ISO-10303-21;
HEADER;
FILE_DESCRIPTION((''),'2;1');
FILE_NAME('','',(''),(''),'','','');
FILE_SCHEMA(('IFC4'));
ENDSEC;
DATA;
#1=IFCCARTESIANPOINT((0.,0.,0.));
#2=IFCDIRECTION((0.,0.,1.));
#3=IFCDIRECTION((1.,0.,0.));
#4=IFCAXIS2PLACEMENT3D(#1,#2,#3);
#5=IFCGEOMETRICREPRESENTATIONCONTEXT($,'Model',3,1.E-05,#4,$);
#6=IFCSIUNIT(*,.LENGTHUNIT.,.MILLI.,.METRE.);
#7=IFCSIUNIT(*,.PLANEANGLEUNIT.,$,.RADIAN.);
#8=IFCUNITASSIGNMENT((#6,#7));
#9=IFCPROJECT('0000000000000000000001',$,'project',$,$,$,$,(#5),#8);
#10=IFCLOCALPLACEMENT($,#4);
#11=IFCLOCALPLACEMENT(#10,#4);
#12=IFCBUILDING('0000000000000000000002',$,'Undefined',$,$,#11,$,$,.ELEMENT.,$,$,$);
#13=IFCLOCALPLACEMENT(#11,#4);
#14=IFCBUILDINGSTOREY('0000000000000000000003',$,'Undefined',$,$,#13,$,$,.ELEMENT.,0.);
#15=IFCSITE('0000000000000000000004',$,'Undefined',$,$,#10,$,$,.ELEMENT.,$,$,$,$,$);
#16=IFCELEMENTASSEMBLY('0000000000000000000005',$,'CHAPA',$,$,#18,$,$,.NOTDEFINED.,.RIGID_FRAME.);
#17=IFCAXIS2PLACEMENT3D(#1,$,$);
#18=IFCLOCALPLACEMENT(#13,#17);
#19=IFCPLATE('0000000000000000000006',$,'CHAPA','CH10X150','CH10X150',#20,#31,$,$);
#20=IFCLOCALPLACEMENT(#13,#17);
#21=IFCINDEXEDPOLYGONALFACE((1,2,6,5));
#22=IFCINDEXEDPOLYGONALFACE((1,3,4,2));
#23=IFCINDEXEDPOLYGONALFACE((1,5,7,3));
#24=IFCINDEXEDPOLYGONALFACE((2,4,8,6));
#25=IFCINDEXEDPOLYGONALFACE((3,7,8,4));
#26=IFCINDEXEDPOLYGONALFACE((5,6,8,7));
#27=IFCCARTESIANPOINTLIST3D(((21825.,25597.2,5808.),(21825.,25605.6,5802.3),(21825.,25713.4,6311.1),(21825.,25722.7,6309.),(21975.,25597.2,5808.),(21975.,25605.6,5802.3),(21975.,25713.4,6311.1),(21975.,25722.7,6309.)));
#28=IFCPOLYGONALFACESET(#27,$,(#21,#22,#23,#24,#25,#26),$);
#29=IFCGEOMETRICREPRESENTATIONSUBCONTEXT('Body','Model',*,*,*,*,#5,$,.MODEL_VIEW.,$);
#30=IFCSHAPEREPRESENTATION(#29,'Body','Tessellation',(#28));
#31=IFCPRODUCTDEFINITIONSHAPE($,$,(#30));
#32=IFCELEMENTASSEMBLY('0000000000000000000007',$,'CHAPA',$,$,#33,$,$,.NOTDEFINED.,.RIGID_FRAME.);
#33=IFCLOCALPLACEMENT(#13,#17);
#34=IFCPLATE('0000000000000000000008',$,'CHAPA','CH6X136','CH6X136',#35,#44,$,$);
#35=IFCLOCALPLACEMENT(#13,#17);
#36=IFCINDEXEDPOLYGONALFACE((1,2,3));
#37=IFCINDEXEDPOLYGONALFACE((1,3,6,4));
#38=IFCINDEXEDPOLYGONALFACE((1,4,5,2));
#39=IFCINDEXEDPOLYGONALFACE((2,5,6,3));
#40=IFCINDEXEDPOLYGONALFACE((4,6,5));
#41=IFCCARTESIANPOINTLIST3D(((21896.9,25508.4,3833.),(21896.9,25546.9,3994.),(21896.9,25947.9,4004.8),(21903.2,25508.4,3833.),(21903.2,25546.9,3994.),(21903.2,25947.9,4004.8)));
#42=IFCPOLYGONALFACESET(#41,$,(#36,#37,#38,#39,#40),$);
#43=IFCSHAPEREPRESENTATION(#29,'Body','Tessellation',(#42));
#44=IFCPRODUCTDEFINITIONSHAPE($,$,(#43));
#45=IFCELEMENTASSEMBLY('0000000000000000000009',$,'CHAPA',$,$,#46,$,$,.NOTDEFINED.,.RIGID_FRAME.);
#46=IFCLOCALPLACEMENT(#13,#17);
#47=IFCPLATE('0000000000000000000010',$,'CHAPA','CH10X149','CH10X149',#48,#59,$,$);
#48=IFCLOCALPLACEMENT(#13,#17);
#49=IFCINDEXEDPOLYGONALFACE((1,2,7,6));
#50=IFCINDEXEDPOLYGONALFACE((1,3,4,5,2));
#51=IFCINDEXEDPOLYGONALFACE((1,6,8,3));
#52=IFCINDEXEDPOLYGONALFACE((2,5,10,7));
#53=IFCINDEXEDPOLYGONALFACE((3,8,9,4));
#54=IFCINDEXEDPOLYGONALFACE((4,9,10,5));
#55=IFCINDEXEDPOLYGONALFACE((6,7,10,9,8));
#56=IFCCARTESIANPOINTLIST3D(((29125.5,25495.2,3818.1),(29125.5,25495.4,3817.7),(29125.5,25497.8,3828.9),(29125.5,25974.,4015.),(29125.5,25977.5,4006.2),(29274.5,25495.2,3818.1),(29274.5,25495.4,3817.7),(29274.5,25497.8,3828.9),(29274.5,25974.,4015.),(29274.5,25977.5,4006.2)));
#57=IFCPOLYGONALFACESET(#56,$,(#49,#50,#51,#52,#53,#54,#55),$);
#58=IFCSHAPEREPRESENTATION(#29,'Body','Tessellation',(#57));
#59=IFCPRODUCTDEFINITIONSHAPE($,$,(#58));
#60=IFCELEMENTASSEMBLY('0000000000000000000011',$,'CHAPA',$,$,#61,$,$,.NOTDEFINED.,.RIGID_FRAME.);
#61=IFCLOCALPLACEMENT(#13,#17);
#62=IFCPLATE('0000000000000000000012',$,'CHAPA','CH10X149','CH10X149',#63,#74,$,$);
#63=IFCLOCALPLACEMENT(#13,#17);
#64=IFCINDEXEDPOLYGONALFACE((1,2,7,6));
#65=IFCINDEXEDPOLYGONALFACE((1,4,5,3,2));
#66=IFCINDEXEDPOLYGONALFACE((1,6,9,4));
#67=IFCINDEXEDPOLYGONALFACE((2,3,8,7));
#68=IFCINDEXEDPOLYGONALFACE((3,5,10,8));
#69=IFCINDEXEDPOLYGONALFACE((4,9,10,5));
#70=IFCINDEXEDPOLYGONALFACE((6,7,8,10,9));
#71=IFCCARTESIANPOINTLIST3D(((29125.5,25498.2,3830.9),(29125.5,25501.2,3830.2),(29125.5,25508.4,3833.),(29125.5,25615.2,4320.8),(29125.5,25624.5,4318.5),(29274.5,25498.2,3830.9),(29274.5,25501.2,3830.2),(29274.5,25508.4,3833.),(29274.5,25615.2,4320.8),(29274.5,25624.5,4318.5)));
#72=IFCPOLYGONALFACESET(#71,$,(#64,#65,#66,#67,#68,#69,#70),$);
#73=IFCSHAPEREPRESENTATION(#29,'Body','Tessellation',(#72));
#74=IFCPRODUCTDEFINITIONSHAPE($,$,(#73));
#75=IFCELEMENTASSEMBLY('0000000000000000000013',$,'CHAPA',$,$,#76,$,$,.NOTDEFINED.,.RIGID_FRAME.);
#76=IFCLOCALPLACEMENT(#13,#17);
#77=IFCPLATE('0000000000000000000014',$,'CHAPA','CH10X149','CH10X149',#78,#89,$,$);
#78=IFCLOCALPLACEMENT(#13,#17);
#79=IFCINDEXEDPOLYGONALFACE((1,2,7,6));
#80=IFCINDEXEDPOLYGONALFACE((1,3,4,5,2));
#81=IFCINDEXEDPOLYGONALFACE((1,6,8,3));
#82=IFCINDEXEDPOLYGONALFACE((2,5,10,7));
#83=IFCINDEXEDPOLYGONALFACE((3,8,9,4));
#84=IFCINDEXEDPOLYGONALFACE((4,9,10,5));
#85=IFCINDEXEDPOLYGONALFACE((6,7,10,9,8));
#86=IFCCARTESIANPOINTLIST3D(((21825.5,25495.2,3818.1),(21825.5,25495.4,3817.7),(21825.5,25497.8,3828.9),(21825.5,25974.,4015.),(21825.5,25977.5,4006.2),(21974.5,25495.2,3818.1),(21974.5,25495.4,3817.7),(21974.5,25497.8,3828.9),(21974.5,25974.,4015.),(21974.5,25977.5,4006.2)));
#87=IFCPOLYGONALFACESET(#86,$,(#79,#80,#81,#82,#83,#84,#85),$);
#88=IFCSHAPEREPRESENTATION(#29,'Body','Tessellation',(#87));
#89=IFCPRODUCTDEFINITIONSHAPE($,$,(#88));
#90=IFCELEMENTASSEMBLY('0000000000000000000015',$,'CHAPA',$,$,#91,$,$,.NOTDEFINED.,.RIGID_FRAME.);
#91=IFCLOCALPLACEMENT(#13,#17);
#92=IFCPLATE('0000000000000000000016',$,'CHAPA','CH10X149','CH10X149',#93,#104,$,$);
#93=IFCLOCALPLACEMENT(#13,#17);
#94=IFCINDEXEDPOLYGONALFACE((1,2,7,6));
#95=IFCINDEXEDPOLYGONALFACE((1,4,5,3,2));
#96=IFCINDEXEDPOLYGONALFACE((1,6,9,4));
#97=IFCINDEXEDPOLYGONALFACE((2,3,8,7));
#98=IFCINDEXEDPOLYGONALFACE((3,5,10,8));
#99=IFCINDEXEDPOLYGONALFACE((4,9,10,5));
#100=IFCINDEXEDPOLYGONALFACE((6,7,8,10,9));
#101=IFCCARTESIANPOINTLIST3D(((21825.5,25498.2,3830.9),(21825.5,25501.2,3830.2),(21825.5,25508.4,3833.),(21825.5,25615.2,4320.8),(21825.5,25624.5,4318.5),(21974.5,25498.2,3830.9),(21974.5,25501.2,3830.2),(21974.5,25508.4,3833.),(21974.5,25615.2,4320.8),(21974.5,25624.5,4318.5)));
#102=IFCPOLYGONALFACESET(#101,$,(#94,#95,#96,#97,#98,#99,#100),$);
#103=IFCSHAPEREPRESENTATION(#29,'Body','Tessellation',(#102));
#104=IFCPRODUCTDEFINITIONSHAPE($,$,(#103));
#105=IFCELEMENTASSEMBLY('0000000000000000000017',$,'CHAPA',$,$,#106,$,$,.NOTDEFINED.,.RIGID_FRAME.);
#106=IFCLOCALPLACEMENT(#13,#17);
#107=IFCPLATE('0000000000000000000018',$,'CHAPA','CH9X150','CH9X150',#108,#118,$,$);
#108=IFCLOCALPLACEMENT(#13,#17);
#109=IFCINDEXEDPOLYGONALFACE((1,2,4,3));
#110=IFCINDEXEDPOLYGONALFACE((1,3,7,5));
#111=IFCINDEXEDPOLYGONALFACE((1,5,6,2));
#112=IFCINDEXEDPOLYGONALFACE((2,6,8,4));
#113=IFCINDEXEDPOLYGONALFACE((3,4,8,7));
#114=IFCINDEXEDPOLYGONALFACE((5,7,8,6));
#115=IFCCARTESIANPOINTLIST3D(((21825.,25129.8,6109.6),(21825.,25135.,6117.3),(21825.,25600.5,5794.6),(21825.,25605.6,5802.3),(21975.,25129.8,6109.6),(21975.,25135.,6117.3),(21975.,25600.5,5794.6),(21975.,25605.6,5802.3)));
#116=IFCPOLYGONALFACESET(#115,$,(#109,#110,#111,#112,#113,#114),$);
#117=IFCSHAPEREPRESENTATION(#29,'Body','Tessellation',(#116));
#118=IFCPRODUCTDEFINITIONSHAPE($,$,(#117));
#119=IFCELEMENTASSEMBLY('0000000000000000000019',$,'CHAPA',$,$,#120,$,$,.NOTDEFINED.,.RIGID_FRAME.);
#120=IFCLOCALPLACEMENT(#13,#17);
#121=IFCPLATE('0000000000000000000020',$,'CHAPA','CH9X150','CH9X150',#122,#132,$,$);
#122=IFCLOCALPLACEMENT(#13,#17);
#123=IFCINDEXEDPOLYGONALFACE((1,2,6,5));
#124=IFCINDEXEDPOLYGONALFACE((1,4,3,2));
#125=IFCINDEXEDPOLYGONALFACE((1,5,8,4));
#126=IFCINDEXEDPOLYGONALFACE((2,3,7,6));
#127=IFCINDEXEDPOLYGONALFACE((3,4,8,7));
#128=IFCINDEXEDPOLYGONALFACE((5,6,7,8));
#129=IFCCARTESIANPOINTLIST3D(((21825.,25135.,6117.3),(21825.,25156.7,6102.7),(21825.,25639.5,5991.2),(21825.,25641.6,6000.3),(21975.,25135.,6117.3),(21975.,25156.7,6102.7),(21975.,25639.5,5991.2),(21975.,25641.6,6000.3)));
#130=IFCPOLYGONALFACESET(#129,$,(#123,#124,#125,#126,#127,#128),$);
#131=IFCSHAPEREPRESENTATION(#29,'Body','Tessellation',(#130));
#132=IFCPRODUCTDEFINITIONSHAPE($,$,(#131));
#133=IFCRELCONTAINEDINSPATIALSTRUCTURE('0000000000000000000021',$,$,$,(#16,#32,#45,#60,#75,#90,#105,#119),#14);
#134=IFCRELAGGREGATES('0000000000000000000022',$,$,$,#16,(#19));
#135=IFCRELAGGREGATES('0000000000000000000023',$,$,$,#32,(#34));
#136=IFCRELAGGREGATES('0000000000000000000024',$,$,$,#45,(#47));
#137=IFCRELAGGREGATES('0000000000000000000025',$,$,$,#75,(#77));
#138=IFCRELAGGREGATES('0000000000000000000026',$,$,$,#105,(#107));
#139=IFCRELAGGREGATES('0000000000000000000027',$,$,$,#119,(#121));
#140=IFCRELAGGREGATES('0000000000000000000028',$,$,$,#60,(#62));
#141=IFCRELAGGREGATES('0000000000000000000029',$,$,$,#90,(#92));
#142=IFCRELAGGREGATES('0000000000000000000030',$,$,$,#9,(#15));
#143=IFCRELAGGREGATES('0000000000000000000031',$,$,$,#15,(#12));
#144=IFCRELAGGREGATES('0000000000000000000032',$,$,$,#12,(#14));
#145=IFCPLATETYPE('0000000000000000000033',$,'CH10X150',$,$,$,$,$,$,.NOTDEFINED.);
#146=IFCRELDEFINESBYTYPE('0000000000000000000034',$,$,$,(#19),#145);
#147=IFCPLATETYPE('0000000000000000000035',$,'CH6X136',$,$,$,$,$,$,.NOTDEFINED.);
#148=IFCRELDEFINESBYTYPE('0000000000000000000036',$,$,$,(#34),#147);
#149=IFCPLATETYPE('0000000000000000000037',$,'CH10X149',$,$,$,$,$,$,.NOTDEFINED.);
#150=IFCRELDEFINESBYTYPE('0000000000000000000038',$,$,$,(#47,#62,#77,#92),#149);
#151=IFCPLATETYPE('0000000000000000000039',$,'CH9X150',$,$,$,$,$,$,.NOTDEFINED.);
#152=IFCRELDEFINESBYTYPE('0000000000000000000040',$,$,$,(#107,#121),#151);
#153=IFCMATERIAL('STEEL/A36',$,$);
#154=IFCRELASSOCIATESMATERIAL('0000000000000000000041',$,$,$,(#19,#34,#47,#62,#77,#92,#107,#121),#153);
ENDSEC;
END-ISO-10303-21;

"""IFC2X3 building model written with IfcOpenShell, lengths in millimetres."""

from ifc_helpers import new_model, si_unit, frame, origin_with_axes, place, context, subcontext, project, spatial, polyline, outline, extrude, clip, halfspace, material, type_object, element, aggregate, save


model = new_model("IFC2X3")

# Units and contexts
model_context = context("Model", 3, precision=1e-05, world=origin_with_axes())
body_context = subcontext(model_context, "Body", "Model", "MODEL_VIEW")
ifc_project = project(units=[si_unit("LENGTHUNIT", "METRE", prefix="MILLI"), si_unit("PLANEANGLEUNIT", "RADIAN")], contexts=[model_context])

# Site, building, storey
site_placement = place(None, origin_with_axes())
site = spatial("IfcSite", under=ifc_project, at=site_placement, Name="Undefined", CompositionType="ELEMENT")
building_placement = place(site_placement, origin_with_axes())
building = spatial("IfcBuilding", under=site, at=building_placement, Name="Undefined", CompositionType="ELEMENT")
storey_placement = place(building_placement, origin_with_axes())
storey = spatial("IfcBuildingStorey", under=building, at=storey_placement, Name="Undefined", CompositionType="ELEMENT", Elevation=0.0)

# Element assembly
assembly_1_placement = place(storey_placement, origin_with_axes())
assembly_1 = element("IfcElementAssembly", 1, at=assembly_1_placement, inside=storey, Name="CHAPA", AssemblyPlace="NOTDEFINED", PredefinedType="RIGID_FRAME")

# Plate
ifc_material_1 = material(Name="STEEL/A36")
plate_type_1 = type_object("IfcPlateType", Name="CH10X150", PredefinedType="NOTDEFINED")
plate_1_placement = place(assembly_1_placement, frame((21975.0, 25718.1, 6310.1), z_axis=(0.0, 0.97433, -0.225124), x_axis=(0.0, -0.225124, -0.97433)))
plate_1 = element("IfcPlate", 2, at=plate_1_placement, type_object=plate_type_1, material=ifc_material_1, Name="CHAPA", Description="CH10X150", ObjectType="CH10X150", context=body_context, shape_type="Clipping", body=[
    clip(extrude(outline(polyline([(0.0, 0.0), (520.0, 0.0), (520.0, 150.0), (0.0, 150.0), (0.0, 0.0)])), frame((0.0, 0.0, -4.8), z_axis=(0.0, 0.0, 1.0), x_axis=(1.0, 0.0, 0.0)), (0.0, 0.0, 1.0), 9.5), halfspace(frame((516.4, -500.0, -4.7), z_axis=(0.934951, 0.0, -0.354778), x_axis=(0.354778, 0.0, 0.934951)), False)),
])
aggregate(assembly_1, [plate_1])

# Element assemblies, plates
assembly_2_placement = place(storey_placement, origin_with_axes())
assembly_2 = element("IfcElementAssembly", 3, at=assembly_2_placement, inside=storey, Name="CHAPA", AssemblyPlace="NOTDEFINED", PredefinedType="RIGID_FRAME")
plate_type_2 = type_object("IfcPlateType", Name="CH6X136", PredefinedType="NOTDEFINED")
plate_2_placement = place(assembly_2_placement, frame((21900.0, 25546.9, 3994.0), z_axis=(-1.0, 0.0, 0.0), x_axis=(0.0, 0.999636, 0.026972)))
plate_2 = element("IfcPlate", 4, at=plate_2_placement, type_object=plate_type_2, material=ifc_material_1, Name="CHAPA", Description="CH6X136", ObjectType="CH6X136", context=body_context, shape_type="SweptSolid", body=[
    extrude(outline(polyline([(0.0, 0.0), (401.1, 0.0), (-42.8, 159.9), (0.0, 0.0)])), frame((0.0, 0.0, -3.1), z_axis=(0.0, 0.0, 1.0), x_axis=(1.0, 0.0, 0.0)), (0.0, 0.0, 1.0), 6.3),
])
aggregate(assembly_2, [plate_2])
assembly_3_placement = place(storey_placement, origin_with_axes())
assembly_3 = element("IfcElementAssembly", 5, at=assembly_3_placement, inside=storey, Name="CHAPA", AssemblyPlace="NOTDEFINED", PredefinedType="RIGID_FRAME")
plate_type_3 = type_object("IfcPlateType", Name="CH10X149", PredefinedType="NOTDEFINED")
plate_3_placement = place(assembly_3_placement, frame((29125.5, 25975.7, 4010.6), z_axis=(0.0, 0.364063, -0.931374), x_axis=(1.0, 0.0, 0.0)))
plate_3 = element("IfcPlate", 6, at=plate_3_placement, type_object=plate_type_3, material=ifc_material_1, Name="CHAPA", Description="CH10X149", ObjectType="CH10X149", context=body_context, shape_type="Clipping", body=[
    clip(extrude(outline(polyline([(0.0, 0.0), (149.0, 0.0), (149.0, 517.6), (0.0, 517.6), (0.0, 0.0)])), frame((0.0, 0.0, -4.8), z_axis=(0.0, 0.0, 1.0), x_axis=(1.0, 0.0, 0.0)), (0.0, 0.0, 1.0), 9.5), halfspace(frame((149.0, 517.9, 4.7), z_axis=(0.0, 0.821204, -0.570634), x_axis=(-1.0, 0.0, 0.0)), False)),
])
aggregate(assembly_3, [plate_3])
assembly_4_placement = place(storey_placement, origin_with_axes())
assembly_4 = element("IfcElementAssembly", 7, at=assembly_4_placement, inside=storey, Name="CHAPA", AssemblyPlace="NOTDEFINED", PredefinedType="RIGID_FRAME")
plate_4_placement = place(assembly_4_placement, frame((29125.5, 25619.9, 4319.6), z_axis=(0.0, 0.972612, -0.232434), x_axis=(1.0, 0.000007, 0.000031)))
plate_4 = element("IfcPlate", 8, at=plate_4_placement, type_object=plate_type_3, material=ifc_material_1, Name="CHAPA", Description="CH10X149", ObjectType="CH10X149", context=body_context, shape_type="Clipping", body=[
    clip(extrude(outline(polyline([(0.0, 0.0), (70.9, 0.0), (149.0, 0.0), (149.0, 503.6), (0.0, 503.6), (0.0, 0.0)])), frame((0.0, 0.0, -4.8), z_axis=(0.0, 0.0, 1.0), x_axis=(1.0, 0.0, 0.0)), (0.0, 0.0, 1.0), 9.5), halfspace(frame((70.9, 499.2, 4.7), z_axis=(-0.000026, 0.821245, 0.570575), x_axis=(-1.0, -0.000032, 0.0)), False)),
])
assembly_5_placement = place(storey_placement, origin_with_axes())
assembly_5 = element("IfcElementAssembly", 9, at=assembly_5_placement, inside=storey, Name="CHAPA", AssemblyPlace="NOTDEFINED", PredefinedType="RIGID_FRAME")
plate_5_placement = place(assembly_5_placement, frame((21825.5, 25975.7, 4010.6), z_axis=(0.0, 0.364063, -0.931374), x_axis=(1.0, 0.0, 0.0)))
plate_5 = element("IfcPlate", 10, at=plate_5_placement, type_object=plate_type_3, material=ifc_material_1, Name="CHAPA", Description="CH10X149", ObjectType="CH10X149", context=body_context, shape_type="Clipping", body=[
    clip(extrude(outline(polyline([(0.0, 0.0), (149.0, 0.0), (149.0, 517.6), (0.0, 517.6), (0.0, 0.0)])), frame((0.0, 0.0, -4.8), z_axis=(0.0, 0.0, 1.0), x_axis=(1.0, 0.0, 0.0)), (0.0, 0.0, 1.0), 9.5), halfspace(frame((149.0, 517.9, 4.7), z_axis=(0.0, 0.821204, -0.570634), x_axis=(-1.0, 0.0, 0.0)), False)),
])
aggregate(assembly_5, [plate_5])
assembly_6_placement = place(storey_placement, origin_with_axes())
assembly_6 = element("IfcElementAssembly", 11, at=assembly_6_placement, inside=storey, Name="CHAPA", AssemblyPlace="NOTDEFINED", PredefinedType="RIGID_FRAME")
plate_6_placement = place(assembly_6_placement, frame((21825.5, 25619.9, 4319.6), z_axis=(0.0, 0.972612, -0.232434), x_axis=(1.0, 0.000007, 0.000031)))
plate_6 = element("IfcPlate", 12, at=plate_6_placement, type_object=plate_type_3, material=ifc_material_1, Name="CHAPA", Description="CH10X149", ObjectType="CH10X149", context=body_context, shape_type="Clipping", body=[
    clip(extrude(outline(polyline([(0.0, 0.0), (70.9, 0.0), (149.0, 0.0), (149.0, 503.6), (0.0, 503.6), (0.0, 0.0)])), frame((0.0, 0.0, -4.8), z_axis=(0.0, 0.0, 1.0), x_axis=(1.0, 0.0, 0.0)), (0.0, 0.0, 1.0), 9.5), halfspace(frame((70.9, 499.2, 4.7), z_axis=(-0.000026, 0.821245, 0.570575), x_axis=(-1.0, -0.000032, 0.0)), False)),
])
assembly_7_placement = place(storey_placement, origin_with_axes())
assembly_7 = element("IfcElementAssembly", 13, at=assembly_7_placement, inside=storey, Name="CHAPA", AssemblyPlace="NOTDEFINED", PredefinedType="RIGID_FRAME")
plate_type_4 = type_object("IfcPlateType", Name="CH9X150", PredefinedType="NOTDEFINED")
plate_7_placement = place(assembly_7_placement, frame((21975.0, 25132.4, 6113.5), z_axis=(0.0, -0.55615, -0.831082), x_axis=(-1.0, 0.0, 0.0)))
plate_7 = element("IfcPlate", 14, at=plate_7_placement, type_object=plate_type_4, material=ifc_material_1, Name="CHAPA", Description="CH9X150", ObjectType="CH9X150", context=body_context, shape_type="SweptSolid", body=[
    extrude(outline(polyline([(0.0, 0.0), (150.0, 0.0), (150.0, 566.3), (0.0, 566.3), (0.0, 0.0)])), frame((0.0, 0.0, -4.7), z_axis=(0.0, 0.0, 1.0), x_axis=(1.0, 0.0, 0.0)), (0.0, 0.0, 1.0), 9.3),
])
aggregate(assembly_7, [plate_7])
assembly_8_placement = place(storey_placement, origin_with_axes())
assembly_8 = element("IfcElementAssembly", 15, at=assembly_8_placement, inside=storey, Name="CHAPA", AssemblyPlace="NOTDEFINED", PredefinedType="RIGID_FRAME")
plate_8_placement = place(assembly_8_placement, frame((21975.0, 25640.6, 5995.7), z_axis=(0.0, -0.225124, -0.97433), x_axis=(0.0, -0.97433, 0.225124)))
plate_8 = element("IfcPlate", 16, at=plate_8_placement, type_object=plate_type_4, material=ifc_material_1, Name="CHAPA", Description="CH9X150", ObjectType="CH9X150", context=body_context, shape_type="Clipping", body=[
    clip(extrude(outline(polyline([(0.0, 0.0), (520.0, 0.0), (520.0, 150.0), (0.0, 150.0), (0.0, 0.0)])), frame((0.0, 0.0, -4.7), z_axis=(0.0, 0.0, 1.0), x_axis=(1.0, 0.0, 0.0)), (0.0, 0.0, 1.0), 9.3), halfspace(frame((520.0, -500.0, -4.7), z_axis=(0.354778, 0.0, 0.934951), x_axis=(-0.934951, 0.0, 0.354778)), False)),
])
aggregate(assembly_8, [plate_8])

aggregate(assembly_4, [plate_4])
aggregate(assembly_6, [plate_6])

save(model, "model.ifc")
